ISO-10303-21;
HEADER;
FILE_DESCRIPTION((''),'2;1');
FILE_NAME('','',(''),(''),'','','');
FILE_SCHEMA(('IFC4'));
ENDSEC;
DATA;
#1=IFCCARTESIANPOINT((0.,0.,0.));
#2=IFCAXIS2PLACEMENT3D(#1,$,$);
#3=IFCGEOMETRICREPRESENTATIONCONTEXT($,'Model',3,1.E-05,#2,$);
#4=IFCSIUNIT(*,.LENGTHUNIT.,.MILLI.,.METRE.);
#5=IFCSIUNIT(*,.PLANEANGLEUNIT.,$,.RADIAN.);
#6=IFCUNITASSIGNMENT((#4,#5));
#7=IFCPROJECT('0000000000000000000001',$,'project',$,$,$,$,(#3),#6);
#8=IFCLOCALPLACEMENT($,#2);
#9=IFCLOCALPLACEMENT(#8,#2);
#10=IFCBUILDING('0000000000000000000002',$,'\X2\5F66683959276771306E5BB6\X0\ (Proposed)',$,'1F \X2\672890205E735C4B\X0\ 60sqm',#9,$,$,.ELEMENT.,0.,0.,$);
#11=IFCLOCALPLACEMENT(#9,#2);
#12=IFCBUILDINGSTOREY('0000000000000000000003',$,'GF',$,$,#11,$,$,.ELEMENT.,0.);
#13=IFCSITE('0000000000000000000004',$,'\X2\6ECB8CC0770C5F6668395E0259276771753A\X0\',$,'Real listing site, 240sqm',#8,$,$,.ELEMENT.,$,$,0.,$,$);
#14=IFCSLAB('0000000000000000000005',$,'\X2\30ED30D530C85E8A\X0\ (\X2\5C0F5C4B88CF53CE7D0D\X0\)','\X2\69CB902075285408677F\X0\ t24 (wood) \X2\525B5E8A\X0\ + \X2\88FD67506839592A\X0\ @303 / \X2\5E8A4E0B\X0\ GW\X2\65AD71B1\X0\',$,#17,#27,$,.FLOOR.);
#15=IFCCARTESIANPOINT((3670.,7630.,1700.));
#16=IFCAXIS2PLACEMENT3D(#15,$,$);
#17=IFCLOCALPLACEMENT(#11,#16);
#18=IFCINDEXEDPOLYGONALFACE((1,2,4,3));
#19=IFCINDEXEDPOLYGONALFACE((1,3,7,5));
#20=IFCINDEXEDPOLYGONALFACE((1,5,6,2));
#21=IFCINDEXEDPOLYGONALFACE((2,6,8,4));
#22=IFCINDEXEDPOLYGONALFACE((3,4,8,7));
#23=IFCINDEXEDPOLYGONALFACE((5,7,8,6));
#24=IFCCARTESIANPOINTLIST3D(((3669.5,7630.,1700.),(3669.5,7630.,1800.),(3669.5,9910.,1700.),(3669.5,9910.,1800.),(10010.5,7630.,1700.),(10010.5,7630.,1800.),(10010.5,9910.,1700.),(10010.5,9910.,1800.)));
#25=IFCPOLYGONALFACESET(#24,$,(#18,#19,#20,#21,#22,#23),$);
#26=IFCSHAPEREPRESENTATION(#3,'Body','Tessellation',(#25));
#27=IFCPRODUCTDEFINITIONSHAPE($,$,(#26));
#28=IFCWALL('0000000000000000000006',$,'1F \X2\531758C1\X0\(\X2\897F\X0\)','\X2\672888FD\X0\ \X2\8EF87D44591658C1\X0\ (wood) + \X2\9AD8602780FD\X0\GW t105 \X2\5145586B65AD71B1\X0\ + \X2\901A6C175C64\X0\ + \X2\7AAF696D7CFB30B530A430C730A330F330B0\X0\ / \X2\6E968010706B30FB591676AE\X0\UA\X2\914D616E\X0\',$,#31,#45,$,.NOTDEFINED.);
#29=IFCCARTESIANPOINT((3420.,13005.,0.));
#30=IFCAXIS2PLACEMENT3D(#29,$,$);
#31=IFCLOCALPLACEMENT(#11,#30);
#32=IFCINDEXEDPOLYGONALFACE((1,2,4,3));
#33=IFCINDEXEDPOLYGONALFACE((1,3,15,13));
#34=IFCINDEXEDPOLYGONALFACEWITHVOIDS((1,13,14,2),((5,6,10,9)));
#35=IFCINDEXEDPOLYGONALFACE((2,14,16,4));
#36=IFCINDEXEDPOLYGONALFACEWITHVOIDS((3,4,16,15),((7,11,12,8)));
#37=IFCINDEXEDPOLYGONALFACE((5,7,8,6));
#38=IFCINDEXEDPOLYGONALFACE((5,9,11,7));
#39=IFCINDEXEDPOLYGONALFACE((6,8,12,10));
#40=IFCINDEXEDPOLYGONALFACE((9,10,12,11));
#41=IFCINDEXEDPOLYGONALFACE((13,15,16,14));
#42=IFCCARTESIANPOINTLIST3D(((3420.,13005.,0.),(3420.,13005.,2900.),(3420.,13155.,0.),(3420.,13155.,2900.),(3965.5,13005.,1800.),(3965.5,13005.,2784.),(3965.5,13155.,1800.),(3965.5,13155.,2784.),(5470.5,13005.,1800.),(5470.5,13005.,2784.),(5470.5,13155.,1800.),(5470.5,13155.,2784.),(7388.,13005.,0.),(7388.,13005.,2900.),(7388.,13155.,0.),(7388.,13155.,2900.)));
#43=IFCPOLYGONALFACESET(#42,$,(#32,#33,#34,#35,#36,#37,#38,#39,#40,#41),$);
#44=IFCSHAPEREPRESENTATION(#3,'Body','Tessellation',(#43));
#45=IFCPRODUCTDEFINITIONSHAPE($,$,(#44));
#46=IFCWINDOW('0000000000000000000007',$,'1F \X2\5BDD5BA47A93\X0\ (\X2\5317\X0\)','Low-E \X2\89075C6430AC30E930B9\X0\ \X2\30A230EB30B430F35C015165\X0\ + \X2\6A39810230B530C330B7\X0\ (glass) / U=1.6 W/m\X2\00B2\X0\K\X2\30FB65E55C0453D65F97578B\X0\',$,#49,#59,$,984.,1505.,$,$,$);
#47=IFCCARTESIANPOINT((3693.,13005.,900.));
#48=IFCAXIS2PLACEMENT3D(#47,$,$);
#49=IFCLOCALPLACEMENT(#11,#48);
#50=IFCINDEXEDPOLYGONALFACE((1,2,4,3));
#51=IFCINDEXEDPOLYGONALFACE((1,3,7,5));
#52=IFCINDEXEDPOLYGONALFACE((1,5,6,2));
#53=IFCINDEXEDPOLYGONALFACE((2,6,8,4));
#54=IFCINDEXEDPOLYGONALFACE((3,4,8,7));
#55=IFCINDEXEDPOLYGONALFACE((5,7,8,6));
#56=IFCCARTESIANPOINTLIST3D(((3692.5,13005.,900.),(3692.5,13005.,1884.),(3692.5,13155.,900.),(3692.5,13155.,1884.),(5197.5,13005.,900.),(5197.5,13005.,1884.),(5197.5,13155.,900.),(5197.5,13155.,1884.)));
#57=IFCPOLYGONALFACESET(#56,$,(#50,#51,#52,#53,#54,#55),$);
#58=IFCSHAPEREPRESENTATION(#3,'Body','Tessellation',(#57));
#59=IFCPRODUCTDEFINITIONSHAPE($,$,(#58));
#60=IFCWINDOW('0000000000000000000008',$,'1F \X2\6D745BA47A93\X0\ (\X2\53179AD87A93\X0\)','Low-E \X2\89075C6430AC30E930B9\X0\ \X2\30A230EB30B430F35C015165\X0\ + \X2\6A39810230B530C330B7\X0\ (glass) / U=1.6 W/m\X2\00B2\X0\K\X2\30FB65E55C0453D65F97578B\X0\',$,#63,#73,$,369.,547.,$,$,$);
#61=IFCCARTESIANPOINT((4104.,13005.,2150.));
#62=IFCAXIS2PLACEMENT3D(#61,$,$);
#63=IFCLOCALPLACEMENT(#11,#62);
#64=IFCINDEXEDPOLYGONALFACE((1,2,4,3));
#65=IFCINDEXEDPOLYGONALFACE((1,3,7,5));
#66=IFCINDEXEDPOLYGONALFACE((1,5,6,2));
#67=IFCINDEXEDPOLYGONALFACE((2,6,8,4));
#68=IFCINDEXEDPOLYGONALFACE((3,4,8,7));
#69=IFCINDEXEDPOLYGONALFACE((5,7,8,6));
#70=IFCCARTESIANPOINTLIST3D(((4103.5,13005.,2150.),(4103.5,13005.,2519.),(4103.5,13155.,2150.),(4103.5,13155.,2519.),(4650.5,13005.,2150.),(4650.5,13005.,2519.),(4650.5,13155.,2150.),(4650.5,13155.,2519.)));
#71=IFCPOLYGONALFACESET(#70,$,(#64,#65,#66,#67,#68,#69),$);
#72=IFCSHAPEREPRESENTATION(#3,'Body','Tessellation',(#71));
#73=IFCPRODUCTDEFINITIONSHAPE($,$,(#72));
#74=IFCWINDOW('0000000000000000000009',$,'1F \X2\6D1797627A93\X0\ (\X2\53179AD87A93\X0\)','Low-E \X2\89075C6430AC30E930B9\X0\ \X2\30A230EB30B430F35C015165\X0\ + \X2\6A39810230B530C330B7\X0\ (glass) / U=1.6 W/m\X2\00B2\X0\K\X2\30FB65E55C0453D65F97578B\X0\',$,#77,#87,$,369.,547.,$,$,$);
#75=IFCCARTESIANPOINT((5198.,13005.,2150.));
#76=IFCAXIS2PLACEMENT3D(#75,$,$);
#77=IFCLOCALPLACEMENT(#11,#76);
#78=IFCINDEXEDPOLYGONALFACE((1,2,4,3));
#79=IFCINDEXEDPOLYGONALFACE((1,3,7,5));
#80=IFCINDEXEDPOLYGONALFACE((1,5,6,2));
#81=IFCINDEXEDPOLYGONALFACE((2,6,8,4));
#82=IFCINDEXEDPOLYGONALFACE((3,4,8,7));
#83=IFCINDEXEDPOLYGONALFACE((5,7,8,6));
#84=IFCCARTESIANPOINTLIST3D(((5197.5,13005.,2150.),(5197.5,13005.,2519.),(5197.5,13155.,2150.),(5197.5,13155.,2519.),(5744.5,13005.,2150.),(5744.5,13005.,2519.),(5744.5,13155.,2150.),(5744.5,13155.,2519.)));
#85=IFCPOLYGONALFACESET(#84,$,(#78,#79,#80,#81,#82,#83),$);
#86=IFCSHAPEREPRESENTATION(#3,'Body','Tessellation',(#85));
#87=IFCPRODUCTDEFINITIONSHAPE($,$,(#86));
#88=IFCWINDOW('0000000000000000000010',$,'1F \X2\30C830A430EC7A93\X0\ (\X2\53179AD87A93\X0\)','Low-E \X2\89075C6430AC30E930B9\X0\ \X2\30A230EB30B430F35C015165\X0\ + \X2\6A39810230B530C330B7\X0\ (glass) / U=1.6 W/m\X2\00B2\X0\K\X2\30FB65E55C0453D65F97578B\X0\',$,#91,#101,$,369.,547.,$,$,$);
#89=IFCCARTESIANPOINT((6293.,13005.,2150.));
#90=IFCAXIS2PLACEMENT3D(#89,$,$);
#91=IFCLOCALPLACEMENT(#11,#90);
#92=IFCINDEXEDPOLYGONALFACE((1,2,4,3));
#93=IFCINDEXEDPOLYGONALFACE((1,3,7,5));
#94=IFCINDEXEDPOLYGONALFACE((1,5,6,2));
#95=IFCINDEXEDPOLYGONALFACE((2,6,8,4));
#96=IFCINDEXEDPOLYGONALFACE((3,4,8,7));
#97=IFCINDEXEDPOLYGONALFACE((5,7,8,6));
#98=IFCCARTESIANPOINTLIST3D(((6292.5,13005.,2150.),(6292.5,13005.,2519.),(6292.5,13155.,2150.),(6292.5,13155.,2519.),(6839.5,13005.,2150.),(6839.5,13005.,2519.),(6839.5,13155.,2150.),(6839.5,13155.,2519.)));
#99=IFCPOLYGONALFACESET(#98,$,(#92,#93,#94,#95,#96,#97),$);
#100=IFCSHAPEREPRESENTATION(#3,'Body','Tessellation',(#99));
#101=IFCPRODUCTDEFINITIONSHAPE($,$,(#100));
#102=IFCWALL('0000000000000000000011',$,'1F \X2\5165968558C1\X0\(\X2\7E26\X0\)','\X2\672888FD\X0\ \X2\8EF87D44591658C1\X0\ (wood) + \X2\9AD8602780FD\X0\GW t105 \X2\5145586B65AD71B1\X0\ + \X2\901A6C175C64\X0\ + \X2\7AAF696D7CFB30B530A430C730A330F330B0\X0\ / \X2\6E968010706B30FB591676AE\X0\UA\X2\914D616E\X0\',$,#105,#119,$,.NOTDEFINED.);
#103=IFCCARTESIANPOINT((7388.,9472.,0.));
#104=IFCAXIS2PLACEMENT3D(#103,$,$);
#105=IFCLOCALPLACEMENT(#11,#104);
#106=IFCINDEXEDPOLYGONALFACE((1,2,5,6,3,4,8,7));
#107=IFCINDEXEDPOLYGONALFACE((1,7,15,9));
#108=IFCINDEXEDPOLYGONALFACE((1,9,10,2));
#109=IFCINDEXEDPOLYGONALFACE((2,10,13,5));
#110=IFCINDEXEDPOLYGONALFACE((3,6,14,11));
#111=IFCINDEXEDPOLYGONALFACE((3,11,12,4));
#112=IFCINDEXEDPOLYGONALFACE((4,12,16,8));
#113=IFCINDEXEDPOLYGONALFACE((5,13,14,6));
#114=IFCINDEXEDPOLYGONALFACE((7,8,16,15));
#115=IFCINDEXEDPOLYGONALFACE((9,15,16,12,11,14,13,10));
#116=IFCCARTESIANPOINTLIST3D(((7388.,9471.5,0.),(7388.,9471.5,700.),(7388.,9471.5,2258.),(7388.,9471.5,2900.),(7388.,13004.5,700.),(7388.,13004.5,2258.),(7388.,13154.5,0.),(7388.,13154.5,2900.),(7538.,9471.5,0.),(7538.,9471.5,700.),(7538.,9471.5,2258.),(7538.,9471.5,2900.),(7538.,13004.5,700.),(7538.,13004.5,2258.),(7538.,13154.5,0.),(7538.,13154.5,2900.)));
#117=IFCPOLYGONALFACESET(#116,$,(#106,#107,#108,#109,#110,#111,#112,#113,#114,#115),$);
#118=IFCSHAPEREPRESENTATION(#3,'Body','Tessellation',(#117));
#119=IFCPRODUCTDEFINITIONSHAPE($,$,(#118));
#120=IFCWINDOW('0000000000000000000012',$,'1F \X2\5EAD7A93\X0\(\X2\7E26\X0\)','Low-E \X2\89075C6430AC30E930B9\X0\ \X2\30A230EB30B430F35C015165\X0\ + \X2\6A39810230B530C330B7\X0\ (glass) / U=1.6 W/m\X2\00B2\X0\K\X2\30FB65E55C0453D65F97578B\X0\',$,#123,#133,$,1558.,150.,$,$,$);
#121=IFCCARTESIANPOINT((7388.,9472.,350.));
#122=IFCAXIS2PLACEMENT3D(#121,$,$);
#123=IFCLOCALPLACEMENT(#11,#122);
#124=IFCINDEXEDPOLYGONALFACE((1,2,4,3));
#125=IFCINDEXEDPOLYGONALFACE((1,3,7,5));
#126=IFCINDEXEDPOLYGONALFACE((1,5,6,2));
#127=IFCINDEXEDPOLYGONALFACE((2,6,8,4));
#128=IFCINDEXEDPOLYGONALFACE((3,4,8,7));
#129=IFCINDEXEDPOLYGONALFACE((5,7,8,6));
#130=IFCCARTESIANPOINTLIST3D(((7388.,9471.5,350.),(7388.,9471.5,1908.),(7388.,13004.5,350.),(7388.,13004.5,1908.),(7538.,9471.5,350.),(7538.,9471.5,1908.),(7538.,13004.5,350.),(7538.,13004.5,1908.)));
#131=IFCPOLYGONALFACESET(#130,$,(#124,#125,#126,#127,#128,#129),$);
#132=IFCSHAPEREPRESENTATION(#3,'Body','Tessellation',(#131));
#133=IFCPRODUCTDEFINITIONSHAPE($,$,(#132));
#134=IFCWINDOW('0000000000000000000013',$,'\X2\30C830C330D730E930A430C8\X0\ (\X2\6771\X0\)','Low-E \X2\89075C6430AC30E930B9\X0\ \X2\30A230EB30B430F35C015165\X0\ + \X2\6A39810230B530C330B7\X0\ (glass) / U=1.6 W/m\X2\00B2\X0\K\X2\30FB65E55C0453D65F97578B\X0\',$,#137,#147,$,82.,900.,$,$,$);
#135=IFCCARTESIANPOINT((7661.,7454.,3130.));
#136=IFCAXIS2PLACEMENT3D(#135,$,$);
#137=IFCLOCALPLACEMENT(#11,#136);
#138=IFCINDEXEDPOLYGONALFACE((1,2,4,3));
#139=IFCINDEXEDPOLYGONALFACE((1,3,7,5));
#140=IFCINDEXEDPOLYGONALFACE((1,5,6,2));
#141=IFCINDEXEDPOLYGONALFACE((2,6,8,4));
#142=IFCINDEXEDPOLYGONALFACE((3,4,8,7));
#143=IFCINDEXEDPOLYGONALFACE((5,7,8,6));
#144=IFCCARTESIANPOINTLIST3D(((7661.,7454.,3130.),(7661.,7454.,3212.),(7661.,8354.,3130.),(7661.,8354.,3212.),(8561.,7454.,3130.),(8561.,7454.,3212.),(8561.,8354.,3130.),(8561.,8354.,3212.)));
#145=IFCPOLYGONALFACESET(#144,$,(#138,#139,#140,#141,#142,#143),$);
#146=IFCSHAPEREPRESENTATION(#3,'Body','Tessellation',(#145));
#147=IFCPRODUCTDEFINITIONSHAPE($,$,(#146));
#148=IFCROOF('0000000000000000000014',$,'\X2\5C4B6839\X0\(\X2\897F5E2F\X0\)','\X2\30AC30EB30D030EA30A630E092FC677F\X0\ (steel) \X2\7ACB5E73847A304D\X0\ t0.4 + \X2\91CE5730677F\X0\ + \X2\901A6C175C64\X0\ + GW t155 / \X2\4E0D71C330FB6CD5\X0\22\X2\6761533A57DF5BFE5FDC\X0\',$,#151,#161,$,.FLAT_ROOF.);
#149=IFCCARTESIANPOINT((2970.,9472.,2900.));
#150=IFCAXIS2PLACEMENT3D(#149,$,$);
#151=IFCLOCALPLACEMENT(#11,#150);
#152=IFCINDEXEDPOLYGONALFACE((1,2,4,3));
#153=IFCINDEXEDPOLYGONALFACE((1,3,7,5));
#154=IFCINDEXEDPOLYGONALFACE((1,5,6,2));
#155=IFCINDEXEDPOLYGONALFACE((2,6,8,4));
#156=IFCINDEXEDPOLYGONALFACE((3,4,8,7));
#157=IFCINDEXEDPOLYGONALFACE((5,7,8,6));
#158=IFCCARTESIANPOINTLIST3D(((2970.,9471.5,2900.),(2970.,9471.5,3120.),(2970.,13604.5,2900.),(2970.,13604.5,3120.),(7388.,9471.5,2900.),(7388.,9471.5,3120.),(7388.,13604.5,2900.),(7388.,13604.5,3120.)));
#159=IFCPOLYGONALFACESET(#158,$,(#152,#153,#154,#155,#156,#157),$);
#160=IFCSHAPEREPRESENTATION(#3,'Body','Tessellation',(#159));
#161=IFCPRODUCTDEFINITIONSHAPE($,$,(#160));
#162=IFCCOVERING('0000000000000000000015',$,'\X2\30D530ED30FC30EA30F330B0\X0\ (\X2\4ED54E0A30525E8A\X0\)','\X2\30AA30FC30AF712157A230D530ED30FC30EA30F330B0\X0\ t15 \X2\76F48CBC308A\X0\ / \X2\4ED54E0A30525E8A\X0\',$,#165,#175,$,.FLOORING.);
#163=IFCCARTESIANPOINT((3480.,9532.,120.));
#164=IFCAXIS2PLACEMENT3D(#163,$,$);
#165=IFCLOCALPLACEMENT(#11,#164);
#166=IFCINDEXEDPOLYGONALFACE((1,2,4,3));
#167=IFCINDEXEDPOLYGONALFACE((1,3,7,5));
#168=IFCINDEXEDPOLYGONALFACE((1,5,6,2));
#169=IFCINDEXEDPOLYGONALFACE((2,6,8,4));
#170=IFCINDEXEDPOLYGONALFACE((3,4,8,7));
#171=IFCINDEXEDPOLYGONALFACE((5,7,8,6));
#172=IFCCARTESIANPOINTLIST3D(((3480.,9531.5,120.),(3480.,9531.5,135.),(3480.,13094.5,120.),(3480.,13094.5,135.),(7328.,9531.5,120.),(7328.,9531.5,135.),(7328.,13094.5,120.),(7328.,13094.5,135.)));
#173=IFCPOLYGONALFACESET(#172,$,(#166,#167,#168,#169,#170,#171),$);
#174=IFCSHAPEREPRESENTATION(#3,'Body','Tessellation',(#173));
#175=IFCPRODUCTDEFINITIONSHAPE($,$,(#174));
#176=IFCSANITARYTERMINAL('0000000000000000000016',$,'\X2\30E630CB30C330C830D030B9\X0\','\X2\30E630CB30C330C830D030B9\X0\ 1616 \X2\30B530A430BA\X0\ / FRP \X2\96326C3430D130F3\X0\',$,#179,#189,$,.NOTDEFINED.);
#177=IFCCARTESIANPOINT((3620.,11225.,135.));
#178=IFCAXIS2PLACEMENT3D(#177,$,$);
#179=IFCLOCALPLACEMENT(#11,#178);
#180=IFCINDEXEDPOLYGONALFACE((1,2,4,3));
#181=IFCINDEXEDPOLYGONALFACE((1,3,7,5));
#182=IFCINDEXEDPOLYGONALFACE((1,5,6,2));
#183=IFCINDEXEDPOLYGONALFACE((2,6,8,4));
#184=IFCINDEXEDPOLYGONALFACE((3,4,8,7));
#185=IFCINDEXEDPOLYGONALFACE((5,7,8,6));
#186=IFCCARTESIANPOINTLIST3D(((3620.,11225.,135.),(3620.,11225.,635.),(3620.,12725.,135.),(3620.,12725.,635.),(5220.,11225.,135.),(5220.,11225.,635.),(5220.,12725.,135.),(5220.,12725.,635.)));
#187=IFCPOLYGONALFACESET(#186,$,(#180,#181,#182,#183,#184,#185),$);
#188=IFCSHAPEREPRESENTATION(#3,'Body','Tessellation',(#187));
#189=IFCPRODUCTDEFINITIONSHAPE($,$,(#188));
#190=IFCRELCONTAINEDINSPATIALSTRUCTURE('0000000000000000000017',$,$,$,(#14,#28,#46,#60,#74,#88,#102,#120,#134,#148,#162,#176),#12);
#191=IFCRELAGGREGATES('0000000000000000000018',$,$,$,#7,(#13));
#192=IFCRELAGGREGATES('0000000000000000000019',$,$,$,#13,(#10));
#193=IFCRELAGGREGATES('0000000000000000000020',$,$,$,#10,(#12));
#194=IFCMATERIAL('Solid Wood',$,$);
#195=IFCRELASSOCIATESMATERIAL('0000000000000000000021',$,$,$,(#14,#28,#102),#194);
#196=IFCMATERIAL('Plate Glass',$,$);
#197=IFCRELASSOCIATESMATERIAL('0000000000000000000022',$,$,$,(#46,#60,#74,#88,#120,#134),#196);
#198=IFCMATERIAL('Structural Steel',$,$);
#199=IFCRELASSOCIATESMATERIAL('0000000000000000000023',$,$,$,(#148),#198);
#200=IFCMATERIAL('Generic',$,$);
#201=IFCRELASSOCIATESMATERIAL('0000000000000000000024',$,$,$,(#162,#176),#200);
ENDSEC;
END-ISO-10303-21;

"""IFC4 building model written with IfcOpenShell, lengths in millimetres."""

from ifc_helpers import new_model, si_unit, frame, frame_2d, origin, place, context, project, spatial, rectangle, extrude, material, element, fill, save


model = new_model("IFC4")

# Units and contexts
model_context = context("Model", 3, precision=1e-05, world=origin())
ifc_project = project(units=[si_unit("LENGTHUNIT", "METRE", prefix="MILLI"), si_unit("PLANEANGLEUNIT", "RADIAN")], contexts=[model_context])

# Site, building, storey
site_placement = place(None, origin())
site = spatial("IfcSite", under=ifc_project, at=site_placement, Name="滋賀県彦根市大東町", ObjectType="Real listing site, 240sqm", CompositionType="ELEMENT", RefElevation=0.0)
building_placement = place(site_placement, origin())
building = spatial("IfcBuilding", under=site, at=building_placement, Name="彦根大東の家 (Proposed)", ObjectType="1F 木造平屋 60sqm", CompositionType="ELEMENT", ElevationOfRefHeight=0.0, ElevationOfTerrain=0.0)
storey_placement = place(building_placement, origin())
storey = spatial("IfcBuildingStorey", under=building, at=storey_placement, Name="GF", CompositionType="ELEMENT", Elevation=0.0)

# Slab
ifc_material_1 = material(Name="Solid Wood")
slab_1_placement = place(storey_placement, frame((3670.0, 7630.0, 1700.0)))
element("IfcSlab", 1, at=slab_1_placement, inside=storey, material=ifc_material_1, Name="ロフト床 (小屋裏収納)", Description="構造用合板 t24 (wood) 剛床 + 製材根太 @303 / 床下 GW断熱", PredefinedType="FLOOR", context=model_context, shape_type="SweptSolid", body=[
    extrude(rectangle(XDim=6341.0, YDim=2280.0, at=frame_2d((3170.0, 1140.0))), frame((3670.0, 7630.0, 1700.0)), (0.0, 0.0, 1.0), 100.0),
])

# Wall, openings, windows
wall_1_placement = place(storey_placement, frame((3420.0, 13005.0, 0.0)))
wall_1 = element("IfcWall", 2, at=wall_1_placement, inside=storey, material=ifc_material_1, Name="1F 北壁(西)", Description="木製 軸組外壁 (wood) + 高性能GW t105 充填断熱 + 通気層 + 窯業系サイディング / 準耐火・外皮UA配慮", PredefinedType="NOTDEFINED", context=model_context, shape_type="SweptSolid", body=[
    extrude(rectangle(XDim=3968.0, YDim=150.0, at=frame_2d((1984.0, 75.0))), frame((3420.0, 13005.0, 0.0)), (0.0, 0.0, 1.0), 2900.0),
])
opening_1_placement = place(storey_placement, frame((3693.0, 13005.0, 900.0)))
opening_1 = element("IfcOpeningElement", 3, at=opening_1_placement, cuts=wall_1, PredefinedType="NOTDEFINED", context=model_context, shape_type="SweptSolid", body=[
    extrude(rectangle(XDim=1505.0, YDim=150.0, at=frame_2d((752.0, 75.0))), frame((3693.0, 13005.0, 900.0)), (0.0, 0.0, 1.0), 984.0),
])
opening_2_placement = place(storey_placement, frame((4104.0, 13005.0, 2150.0)))
opening_2 = element("IfcOpeningElement", 4, at=opening_2_placement, cuts=wall_1, PredefinedType="NOTDEFINED", context=model_context, shape_type="SweptSolid", body=[
    extrude(rectangle(XDim=547.0, YDim=150.0, at=frame_2d((273.0, 75.0))), frame((4104.0, 13005.0, 2150.0)), (0.0, 0.0, 1.0), 369.0),
])
opening_3_placement = place(storey_placement, frame((5198.0, 13005.0, 2150.0)))
opening_3 = element("IfcOpeningElement", 5, at=opening_3_placement, cuts=wall_1, PredefinedType="NOTDEFINED", context=model_context, shape_type="SweptSolid", body=[
    extrude(rectangle(XDim=547.0, YDim=150.0, at=frame_2d((273.0, 75.0))), frame((5198.0, 13005.0, 2150.0)), (0.0, 0.0, 1.0), 369.0),
])
opening_4_placement = place(storey_placement, frame((6293.0, 13005.0, 2150.0)))
opening_4 = element("IfcOpeningElement", 6, at=opening_4_placement, cuts=wall_1, PredefinedType="NOTDEFINED", context=model_context, shape_type="SweptSolid", body=[
    extrude(rectangle(XDim=547.0, YDim=150.0, at=frame_2d((273.0, 75.0))), frame((6293.0, 13005.0, 2150.0)), (0.0, 0.0, 1.0), 369.0),
])
ifc_material_2 = material(Name="Plate Glass")
window_1_placement = place(storey_placement, frame((3693.0, 13005.0, 900.0)))
window_1 = element("IfcWindow", 7, at=window_1_placement, inside=storey, material=ifc_material_2, Name="1F 寝室窓 (北)", Description="Low-E 複層ガラス アルゴン封入 + 樹脂サッシ (glass) / U=1.6 W/m²K・日射取得型", OverallHeight=984.0, OverallWidth=1505.0, context=model_context, shape_type="SweptSolid", body=[
    extrude(rectangle(XDim=1505.0, YDim=150.0, at=frame_2d((752.0, 75.0))), frame((3693.0, 13005.0, 900.0)), (0.0, 0.0, 1.0), 984.0),
])
fill(opening_1, window_1)
window_2_placement = place(storey_placement, frame((4104.0, 13005.0, 2150.0)))
window_2 = element("IfcWindow", 8, at=window_2_placement, inside=storey, material=ifc_material_2, Name="1F 浴室窓 (北高窓)", Description="Low-E 複層ガラス アルゴン封入 + 樹脂サッシ (glass) / U=1.6 W/m²K・日射取得型", OverallHeight=369.0, OverallWidth=547.0, context=model_context, shape_type="SweptSolid", body=[
    extrude(rectangle(XDim=547.0, YDim=150.0, at=frame_2d((273.0, 75.0))), frame((4104.0, 13005.0, 2150.0)), (0.0, 0.0, 1.0), 369.0),
])
fill(opening_2, window_2)
window_3_placement = place(storey_placement, frame((5198.0, 13005.0, 2150.0)))
window_3 = element("IfcWindow", 9, at=window_3_placement, inside=storey, material=ifc_material_2, Name="1F 洗面窓 (北高窓)", Description="Low-E 複層ガラス アルゴン封入 + 樹脂サッシ (glass) / U=1.6 W/m²K・日射取得型", OverallHeight=369.0, OverallWidth=547.0, context=model_context, shape_type="SweptSolid", body=[
    extrude(rectangle(XDim=547.0, YDim=150.0, at=frame_2d((273.0, 75.0))), frame((5198.0, 13005.0, 2150.0)), (0.0, 0.0, 1.0), 369.0),
])
fill(opening_3, window_3)
window_4_placement = place(storey_placement, frame((6293.0, 13005.0, 2150.0)))
window_4 = element("IfcWindow", 10, at=window_4_placement, inside=storey, material=ifc_material_2, Name="1F トイレ窓 (北高窓)", Description="Low-E 複層ガラス アルゴン封入 + 樹脂サッシ (glass) / U=1.6 W/m²K・日射取得型", OverallHeight=369.0, OverallWidth=547.0, context=model_context, shape_type="SweptSolid", body=[
    extrude(rectangle(XDim=547.0, YDim=150.0, at=frame_2d((273.0, 75.0))), frame((6293.0, 13005.0, 2150.0)), (0.0, 0.0, 1.0), 369.0),
])
fill(opening_4, window_4)

# Wall, opening, window
wall_2_placement = place(storey_placement, frame((7388.0, 9472.0, 0.0)))
wall_2 = element("IfcWall", 11, at=wall_2_placement, inside=storey, material=ifc_material_1, Name="1F 入隅壁(縦)", Description="木製 軸組外壁 (wood) + 高性能GW t105 充填断熱 + 通気層 + 窯業系サイディング / 準耐火・外皮UA配慮", PredefinedType="NOTDEFINED", context=model_context, shape_type="SweptSolid", body=[
    extrude(rectangle(XDim=150.0, YDim=3683.0, at=frame_2d((75.0, 1841.0))), frame((7388.0, 9472.0, 0.0)), (0.0, 0.0, 1.0), 2900.0),
])
opening_5_placement = place(storey_placement, frame((7388.0, 9472.0, 350.0)))
opening_5 = element("IfcOpeningElement", 12, at=opening_5_placement, cuts=wall_2, PredefinedType="NOTDEFINED", context=model_context, shape_type="SweptSolid", body=[
    extrude(rectangle(XDim=150.0, YDim=3533.0, at=frame_2d((75.0, 1766.0))), frame((7388.0, 9472.0, 350.0)), (0.0, 0.0, 1.0), 1558.0),
])
window_5_placement = place(storey_placement, frame((7388.0, 9472.0, 350.0)))
window_5 = element("IfcWindow", 13, at=window_5_placement, inside=storey, material=ifc_material_2, Name="1F 庭窓(縦)", Description="Low-E 複層ガラス アルゴン封入 + 樹脂サッシ (glass) / U=1.6 W/m²K・日射取得型", OverallHeight=1558.0, OverallWidth=150.0, context=model_context, shape_type="SweptSolid", body=[
    extrude(rectangle(XDim=150.0, YDim=3533.0, at=frame_2d((75.0, 1766.0))), frame((7388.0, 9472.0, 350.0)), (0.0, 0.0, 1.0), 1558.0),
])
fill(opening_5, window_5)

# Window
window_6_placement = place(storey_placement, frame((7661.0, 7454.0, 3130.0)))
element("IfcWindow", 14, at=window_6_placement, inside=storey, material=ifc_material_2, Name="トップライト (東)", Description="Low-E 複層ガラス アルゴン封入 + 樹脂サッシ (glass) / U=1.6 W/m²K・日射取得型", OverallHeight=82.0, OverallWidth=900.0, context=model_context, shape_type="SweptSolid", body=[
    extrude(rectangle(XDim=900.0, YDim=900.0, at=frame_2d((450.0, 450.0))), frame((7661.0, 7454.0, 3130.0)), (0.0, 0.0, 1.0), 82.0),
])

# Roof
ifc_material_3 = material(Name="Structural Steel")
roof_placement = place(storey_placement, frame((2970.0, 9472.0, 2900.0)))
element("IfcRoof", 15, at=roof_placement, inside=storey, material=ifc_material_3, Name="屋根(西帯)", Description="ガルバリウム鋼板 (steel) 立平葺き t0.4 + 野地板 + 通気層 + GW t155 / 不燃・法22条区域対応", PredefinedType="FLAT_ROOF", context=model_context, shape_type="SweptSolid", body=[
    extrude(rectangle(XDim=4418.0, YDim=4133.0, at=frame_2d((2209.0, 2066.0))), frame((2970.0, 9472.0, 2900.0)), (0.0, 0.0, 1.0), 220.0),
])

# Covering
ifc_material_4 = material(Name="Generic")
covering_placement = place(storey_placement, frame((3480.0, 9532.0, 120.0)))
element("IfcCovering", 16, at=covering_placement, inside=storey, material=ifc_material_4, Name="フローリング (仕上げ床)", Description="オーク無垢フローリング t15 直貼り / 仕上げ床", PredefinedType="FLOORING", context=model_context, shape_type="SweptSolid", body=[
    extrude(rectangle(XDim=3848.0, YDim=3563.0, at=frame_2d((1924.0, 1781.0))), frame((3480.0, 9532.0, 120.0)), (0.0, 0.0, 1.0), 15.0),
])

# Sanitary terminal
sanitary_terminal_1_placement = place(storey_placement, frame((3620.0, 11225.0, 135.0)))
element("IfcSanitaryTerminal", 17, at=sanitary_terminal_1_placement, inside=storey, material=ifc_material_4, Name="ユニットバス", Description="ユニットバス 1616 サイズ / FRP 防水パン", PredefinedType="NOTDEFINED", context=model_context, shape_type="SweptSolid", body=[
    extrude(rectangle(XDim=1600.0, YDim=1500.0, at=frame_2d((800.0, 750.0))), frame((3620.0, 11225.0, 135.0)), (0.0, 0.0, 1.0), 500.0),
])

save(model, "model.ifc")
